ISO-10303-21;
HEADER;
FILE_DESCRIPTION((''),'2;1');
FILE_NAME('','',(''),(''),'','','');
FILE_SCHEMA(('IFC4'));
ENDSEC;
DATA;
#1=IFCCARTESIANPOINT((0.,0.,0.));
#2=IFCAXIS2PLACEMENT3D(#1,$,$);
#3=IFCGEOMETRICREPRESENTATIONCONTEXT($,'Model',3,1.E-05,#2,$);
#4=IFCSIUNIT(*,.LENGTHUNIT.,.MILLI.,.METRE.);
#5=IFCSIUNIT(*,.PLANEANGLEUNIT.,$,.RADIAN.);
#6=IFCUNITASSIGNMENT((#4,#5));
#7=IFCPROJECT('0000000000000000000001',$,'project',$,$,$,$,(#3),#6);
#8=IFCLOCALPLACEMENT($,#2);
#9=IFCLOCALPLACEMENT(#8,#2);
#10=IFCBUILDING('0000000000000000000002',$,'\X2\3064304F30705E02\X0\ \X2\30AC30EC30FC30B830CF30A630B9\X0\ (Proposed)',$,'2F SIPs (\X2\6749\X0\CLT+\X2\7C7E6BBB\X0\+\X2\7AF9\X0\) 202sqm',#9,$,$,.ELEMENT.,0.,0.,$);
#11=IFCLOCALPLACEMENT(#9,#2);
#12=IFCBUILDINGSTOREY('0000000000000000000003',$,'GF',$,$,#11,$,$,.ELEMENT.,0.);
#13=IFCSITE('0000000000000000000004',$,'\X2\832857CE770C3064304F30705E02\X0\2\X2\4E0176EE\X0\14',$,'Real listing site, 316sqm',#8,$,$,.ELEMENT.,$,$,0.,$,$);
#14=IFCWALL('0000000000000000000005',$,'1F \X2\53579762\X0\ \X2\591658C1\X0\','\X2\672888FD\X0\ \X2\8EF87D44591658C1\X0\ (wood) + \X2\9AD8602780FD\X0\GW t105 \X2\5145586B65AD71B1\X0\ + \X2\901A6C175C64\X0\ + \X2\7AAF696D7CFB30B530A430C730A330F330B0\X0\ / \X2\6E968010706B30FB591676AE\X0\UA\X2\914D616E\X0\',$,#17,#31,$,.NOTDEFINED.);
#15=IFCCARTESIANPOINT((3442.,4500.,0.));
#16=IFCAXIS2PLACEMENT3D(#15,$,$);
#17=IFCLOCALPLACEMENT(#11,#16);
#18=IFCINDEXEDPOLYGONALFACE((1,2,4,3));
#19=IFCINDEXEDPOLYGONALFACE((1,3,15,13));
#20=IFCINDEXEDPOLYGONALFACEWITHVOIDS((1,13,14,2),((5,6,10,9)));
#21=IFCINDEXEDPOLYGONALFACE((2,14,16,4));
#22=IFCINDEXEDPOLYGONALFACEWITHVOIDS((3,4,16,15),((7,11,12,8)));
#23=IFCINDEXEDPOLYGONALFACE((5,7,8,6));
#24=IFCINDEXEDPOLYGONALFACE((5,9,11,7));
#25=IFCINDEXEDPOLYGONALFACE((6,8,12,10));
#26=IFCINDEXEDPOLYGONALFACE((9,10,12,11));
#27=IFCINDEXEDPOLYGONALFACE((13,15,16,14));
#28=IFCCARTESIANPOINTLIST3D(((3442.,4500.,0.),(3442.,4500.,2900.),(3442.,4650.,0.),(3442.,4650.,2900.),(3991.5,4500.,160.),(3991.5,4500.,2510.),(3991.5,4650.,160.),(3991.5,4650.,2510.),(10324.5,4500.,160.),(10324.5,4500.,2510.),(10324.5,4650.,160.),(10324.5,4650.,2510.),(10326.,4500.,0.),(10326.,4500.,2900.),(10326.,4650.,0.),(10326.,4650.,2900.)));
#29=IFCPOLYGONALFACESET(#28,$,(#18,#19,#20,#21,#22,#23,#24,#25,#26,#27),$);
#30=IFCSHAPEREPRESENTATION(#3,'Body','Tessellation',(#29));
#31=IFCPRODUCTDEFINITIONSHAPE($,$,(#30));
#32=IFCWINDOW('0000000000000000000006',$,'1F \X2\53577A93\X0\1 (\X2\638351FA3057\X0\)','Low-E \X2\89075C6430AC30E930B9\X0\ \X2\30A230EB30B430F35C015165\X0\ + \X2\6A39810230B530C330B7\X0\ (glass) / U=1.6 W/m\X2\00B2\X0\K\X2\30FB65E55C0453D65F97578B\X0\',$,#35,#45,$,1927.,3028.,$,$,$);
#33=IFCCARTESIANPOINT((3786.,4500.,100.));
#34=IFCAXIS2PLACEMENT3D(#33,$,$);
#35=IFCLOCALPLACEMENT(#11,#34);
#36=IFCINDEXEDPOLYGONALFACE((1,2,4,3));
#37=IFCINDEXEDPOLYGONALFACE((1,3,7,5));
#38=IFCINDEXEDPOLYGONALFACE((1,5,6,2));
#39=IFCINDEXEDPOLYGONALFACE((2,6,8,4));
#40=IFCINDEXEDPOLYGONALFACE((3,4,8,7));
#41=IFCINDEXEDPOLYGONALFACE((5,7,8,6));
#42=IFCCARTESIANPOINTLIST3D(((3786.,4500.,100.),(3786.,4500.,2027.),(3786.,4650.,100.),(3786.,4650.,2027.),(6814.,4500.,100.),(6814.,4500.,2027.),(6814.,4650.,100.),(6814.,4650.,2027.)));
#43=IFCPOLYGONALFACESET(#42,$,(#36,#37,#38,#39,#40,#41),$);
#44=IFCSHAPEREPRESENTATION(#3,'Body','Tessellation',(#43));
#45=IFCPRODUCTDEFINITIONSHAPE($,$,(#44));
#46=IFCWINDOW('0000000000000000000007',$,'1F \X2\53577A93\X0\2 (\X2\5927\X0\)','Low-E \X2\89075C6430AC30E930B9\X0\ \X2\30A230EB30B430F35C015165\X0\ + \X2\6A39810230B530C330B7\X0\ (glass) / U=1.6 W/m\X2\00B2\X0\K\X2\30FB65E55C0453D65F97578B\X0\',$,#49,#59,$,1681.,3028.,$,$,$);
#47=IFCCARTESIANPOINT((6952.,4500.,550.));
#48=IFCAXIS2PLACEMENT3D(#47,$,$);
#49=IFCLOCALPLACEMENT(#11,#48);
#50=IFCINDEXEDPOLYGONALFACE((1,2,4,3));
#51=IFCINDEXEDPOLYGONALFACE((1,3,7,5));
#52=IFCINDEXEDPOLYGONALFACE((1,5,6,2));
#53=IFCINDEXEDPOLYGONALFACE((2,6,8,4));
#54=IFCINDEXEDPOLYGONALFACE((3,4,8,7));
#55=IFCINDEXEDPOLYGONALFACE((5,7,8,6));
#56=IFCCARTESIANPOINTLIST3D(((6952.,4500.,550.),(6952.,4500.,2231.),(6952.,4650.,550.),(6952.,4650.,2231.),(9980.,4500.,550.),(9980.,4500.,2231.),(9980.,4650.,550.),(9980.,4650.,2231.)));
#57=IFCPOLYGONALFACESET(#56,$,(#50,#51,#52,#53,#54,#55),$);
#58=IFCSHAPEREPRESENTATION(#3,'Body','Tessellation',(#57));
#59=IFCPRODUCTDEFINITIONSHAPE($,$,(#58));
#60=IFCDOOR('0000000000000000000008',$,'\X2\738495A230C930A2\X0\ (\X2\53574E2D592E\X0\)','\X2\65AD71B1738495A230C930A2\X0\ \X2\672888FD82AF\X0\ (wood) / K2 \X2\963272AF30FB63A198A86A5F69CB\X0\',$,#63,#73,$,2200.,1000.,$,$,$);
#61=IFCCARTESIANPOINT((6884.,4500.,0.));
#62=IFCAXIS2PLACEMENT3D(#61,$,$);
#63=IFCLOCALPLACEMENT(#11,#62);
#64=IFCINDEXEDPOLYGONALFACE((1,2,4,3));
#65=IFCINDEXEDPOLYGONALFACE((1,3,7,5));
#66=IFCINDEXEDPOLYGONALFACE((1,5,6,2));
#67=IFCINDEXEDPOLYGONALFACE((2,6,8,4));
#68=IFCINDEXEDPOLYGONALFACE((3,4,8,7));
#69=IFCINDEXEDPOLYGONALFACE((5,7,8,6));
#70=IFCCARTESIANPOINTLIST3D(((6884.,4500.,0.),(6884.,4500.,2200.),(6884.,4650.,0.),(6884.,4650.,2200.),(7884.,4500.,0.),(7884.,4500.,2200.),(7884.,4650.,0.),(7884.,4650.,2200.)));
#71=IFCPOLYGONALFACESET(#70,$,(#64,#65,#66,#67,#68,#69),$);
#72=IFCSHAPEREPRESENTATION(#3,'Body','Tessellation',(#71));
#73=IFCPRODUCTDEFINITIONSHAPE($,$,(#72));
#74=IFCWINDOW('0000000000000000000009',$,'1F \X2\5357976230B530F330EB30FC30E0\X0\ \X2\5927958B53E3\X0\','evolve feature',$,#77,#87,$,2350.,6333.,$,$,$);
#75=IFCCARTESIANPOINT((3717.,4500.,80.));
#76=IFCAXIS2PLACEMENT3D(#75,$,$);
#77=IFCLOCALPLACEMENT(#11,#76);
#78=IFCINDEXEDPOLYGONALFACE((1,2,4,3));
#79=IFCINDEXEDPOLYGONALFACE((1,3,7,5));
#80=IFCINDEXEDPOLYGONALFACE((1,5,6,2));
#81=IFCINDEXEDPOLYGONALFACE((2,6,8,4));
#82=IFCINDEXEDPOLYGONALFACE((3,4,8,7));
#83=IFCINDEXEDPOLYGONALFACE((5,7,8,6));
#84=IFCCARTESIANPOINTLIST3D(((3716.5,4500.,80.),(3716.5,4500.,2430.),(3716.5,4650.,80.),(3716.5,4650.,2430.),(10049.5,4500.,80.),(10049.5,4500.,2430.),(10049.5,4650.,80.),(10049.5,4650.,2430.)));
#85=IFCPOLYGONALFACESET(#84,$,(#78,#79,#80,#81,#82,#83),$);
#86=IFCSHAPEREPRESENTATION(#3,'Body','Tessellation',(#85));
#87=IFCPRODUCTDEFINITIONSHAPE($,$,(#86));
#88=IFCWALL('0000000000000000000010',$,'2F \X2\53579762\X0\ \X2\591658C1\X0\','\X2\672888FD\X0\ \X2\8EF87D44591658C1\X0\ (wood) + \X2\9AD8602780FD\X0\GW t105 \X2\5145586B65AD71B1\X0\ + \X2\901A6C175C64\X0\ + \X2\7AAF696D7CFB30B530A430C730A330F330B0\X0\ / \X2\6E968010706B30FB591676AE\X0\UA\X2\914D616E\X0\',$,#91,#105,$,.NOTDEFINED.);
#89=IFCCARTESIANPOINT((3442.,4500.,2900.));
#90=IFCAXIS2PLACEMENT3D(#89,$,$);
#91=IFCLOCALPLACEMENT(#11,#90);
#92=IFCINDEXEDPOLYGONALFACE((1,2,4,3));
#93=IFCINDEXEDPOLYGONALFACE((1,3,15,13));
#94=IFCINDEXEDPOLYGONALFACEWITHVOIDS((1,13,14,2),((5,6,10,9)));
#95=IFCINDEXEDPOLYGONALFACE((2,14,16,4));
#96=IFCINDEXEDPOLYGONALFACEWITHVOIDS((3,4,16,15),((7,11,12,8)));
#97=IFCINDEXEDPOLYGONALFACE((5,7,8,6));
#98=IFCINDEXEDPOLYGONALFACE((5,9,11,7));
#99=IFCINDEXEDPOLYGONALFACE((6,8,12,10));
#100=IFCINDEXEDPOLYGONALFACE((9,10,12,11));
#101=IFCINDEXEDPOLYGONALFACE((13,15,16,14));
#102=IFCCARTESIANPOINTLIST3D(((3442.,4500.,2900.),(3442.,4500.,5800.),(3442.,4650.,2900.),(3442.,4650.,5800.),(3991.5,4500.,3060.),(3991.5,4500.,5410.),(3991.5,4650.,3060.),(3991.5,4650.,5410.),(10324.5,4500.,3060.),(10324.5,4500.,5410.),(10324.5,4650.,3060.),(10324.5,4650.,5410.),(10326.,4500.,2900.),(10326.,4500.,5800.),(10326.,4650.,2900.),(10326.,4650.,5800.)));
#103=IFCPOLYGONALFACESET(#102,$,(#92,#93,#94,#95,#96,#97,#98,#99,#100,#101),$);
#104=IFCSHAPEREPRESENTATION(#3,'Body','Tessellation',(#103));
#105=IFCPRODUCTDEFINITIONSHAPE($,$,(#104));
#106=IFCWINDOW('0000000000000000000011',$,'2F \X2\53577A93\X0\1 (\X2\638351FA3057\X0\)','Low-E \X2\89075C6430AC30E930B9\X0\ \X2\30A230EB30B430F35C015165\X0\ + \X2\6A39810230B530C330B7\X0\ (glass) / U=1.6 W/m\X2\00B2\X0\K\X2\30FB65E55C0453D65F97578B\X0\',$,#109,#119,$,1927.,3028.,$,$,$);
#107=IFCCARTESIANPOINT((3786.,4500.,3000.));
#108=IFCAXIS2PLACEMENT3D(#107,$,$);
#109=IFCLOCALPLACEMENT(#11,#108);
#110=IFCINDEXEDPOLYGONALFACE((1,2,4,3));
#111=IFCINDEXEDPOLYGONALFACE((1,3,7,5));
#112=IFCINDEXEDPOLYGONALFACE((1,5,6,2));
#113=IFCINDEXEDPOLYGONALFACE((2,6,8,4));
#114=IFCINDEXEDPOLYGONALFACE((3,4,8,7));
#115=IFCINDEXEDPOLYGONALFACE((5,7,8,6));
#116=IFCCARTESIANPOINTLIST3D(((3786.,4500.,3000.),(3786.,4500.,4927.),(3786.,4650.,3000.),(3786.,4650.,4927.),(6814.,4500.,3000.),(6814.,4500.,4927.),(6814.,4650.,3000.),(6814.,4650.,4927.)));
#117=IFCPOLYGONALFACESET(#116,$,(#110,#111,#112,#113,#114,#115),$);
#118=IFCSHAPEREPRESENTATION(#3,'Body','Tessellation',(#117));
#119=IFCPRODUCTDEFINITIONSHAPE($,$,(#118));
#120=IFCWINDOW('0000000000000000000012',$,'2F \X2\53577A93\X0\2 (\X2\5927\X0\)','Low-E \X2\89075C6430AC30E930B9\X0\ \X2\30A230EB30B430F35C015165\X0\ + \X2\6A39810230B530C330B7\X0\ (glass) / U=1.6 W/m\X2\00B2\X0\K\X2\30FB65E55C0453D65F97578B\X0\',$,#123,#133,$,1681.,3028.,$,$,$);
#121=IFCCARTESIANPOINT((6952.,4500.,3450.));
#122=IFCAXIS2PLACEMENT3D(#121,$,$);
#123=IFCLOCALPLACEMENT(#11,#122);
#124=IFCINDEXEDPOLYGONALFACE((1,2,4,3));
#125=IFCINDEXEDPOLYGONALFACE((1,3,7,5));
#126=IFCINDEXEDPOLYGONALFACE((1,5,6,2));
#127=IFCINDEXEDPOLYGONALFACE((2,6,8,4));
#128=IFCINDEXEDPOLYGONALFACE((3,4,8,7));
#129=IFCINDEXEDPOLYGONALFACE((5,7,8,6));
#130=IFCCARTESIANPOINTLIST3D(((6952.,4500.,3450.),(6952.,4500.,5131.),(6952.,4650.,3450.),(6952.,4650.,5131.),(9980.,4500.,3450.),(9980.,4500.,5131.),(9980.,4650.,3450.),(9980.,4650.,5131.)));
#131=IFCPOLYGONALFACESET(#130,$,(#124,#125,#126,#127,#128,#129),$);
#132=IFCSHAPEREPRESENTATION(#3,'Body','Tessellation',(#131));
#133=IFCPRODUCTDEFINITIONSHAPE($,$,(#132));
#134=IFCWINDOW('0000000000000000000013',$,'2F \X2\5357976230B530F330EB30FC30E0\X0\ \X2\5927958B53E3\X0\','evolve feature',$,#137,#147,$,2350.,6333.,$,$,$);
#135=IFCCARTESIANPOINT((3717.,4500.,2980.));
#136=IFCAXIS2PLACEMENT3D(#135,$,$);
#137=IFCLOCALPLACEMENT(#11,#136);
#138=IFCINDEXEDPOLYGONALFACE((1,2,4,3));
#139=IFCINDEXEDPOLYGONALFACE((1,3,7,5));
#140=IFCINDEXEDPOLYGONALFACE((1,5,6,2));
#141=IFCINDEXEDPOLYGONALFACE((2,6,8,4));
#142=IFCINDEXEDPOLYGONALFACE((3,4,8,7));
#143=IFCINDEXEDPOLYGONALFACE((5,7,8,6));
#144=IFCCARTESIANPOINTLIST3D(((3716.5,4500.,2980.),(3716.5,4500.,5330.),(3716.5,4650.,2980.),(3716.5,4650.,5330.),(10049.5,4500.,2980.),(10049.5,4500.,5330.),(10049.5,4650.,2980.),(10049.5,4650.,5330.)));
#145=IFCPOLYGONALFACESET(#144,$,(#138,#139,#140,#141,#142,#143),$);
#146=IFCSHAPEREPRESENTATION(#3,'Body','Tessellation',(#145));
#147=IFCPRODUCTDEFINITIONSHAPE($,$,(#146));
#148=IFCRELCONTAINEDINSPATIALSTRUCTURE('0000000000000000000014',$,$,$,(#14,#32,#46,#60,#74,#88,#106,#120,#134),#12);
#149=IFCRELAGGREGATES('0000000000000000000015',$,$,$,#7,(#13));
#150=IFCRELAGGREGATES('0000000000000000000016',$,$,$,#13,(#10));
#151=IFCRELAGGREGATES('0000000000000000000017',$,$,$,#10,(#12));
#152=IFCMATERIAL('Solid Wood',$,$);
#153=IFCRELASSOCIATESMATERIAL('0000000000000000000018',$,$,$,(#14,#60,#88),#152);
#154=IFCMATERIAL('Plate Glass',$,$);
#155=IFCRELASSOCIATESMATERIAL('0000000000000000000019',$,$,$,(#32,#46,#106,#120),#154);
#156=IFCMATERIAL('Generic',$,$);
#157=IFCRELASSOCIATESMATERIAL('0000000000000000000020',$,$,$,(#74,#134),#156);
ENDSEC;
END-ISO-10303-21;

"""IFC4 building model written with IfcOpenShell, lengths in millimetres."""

from ifc_helpers import new_model, si_unit, frame, frame_2d, origin, place, context, project, spatial, rectangle, extrude, material, element, fill, save


model = new_model("IFC4")

# Units and contexts
model_context = context("Model", 3, precision=1e-05, world=origin())
ifc_project = project(units=[si_unit("LENGTHUNIT", "METRE", prefix="MILLI"), si_unit("PLANEANGLEUNIT", "RADIAN")], contexts=[model_context])

# Site, building, storey
site_placement = place(None, origin())
site = spatial("IfcSite", under=ifc_project, at=site_placement, Name="茨城県つくば市2丁目14", ObjectType="Real listing site, 316sqm", CompositionType="ELEMENT", RefElevation=0.0)
building_placement = place(site_placement, origin())
building = spatial("IfcBuilding", under=site, at=building_placement, Name="つくば市 ガレージハウス (Proposed)", ObjectType="2F SIPs (杉CLT+籾殻+竹) 202sqm", CompositionType="ELEMENT", ElevationOfRefHeight=0.0, ElevationOfTerrain=0.0)
storey_placement = place(building_placement, origin())
storey = spatial("IfcBuildingStorey", under=building, at=storey_placement, Name="GF", CompositionType="ELEMENT", Elevation=0.0)

# Shared definitions
ifc_material_1 = material(Name="Solid Wood")

# Wall, openings, windows, door
wall_1_placement = place(storey_placement, frame((3442.0, 4500.0, 0.0)))
wall_1 = element("IfcWall", 1, at=wall_1_placement, inside=storey, material=ifc_material_1, Name="1F 南面 外壁", Description="木製 軸組外壁 (wood) + 高性能GW t105 充填断熱 + 通気層 + 窯業系サイディング / 準耐火・外皮UA配慮", PredefinedType="NOTDEFINED", context=model_context, shape_type="SweptSolid", body=[
    extrude(rectangle(XDim=6884.0, YDim=150.0, at=frame_2d((3442.0, 75.0))), frame((3442.0, 4500.0, 0.0)), (0.0, 0.0, 1.0), 2900.0),
])
opening_1_placement = place(storey_placement, frame((3786.0, 4500.0, 100.0)))
opening_1 = element("IfcOpeningElement", 2, at=opening_1_placement, cuts=wall_1, PredefinedType="NOTDEFINED", context=model_context, shape_type="SweptSolid", body=[
    extrude(rectangle(XDim=3028.0, YDim=150.0, at=frame_2d((1514.0, 75.0))), frame((3786.0, 4500.0, 100.0)), (0.0, 0.0, 1.0), 1927.0),
])
opening_2_placement = place(storey_placement, frame((6952.0, 4500.0, 550.0)))
opening_2 = element("IfcOpeningElement", 3, at=opening_2_placement, cuts=wall_1, PredefinedType="NOTDEFINED", context=model_context, shape_type="SweptSolid", body=[
    extrude(rectangle(XDim=3028.0, YDim=150.0, at=frame_2d((1514.0, 75.0))), frame((6952.0, 4500.0, 550.0)), (0.0, 0.0, 1.0), 1681.0),
])
opening_3_placement = place(storey_placement, frame((6884.0, 4500.0, 0.0)))
opening_3 = element("IfcOpeningElement", 4, at=opening_3_placement, cuts=wall_1, PredefinedType="NOTDEFINED", context=model_context, shape_type="SweptSolid", body=[
    extrude(rectangle(XDim=1000.0, YDim=150.0, at=frame_2d((500.0, 75.0))), frame((6884.0, 4500.0, 0.0)), (0.0, 0.0, 1.0), 2200.0),
])
opening_4_placement = place(storey_placement, frame((3717.0, 4500.0, 80.0)))
opening_4 = element("IfcOpeningElement", 5, at=opening_4_placement, cuts=wall_1, PredefinedType="NOTDEFINED", context=model_context, shape_type="SweptSolid", body=[
    extrude(rectangle(XDim=6333.0, YDim=150.0, at=frame_2d((3166.0, 75.0))), frame((3717.0, 4500.0, 80.0)), (0.0, 0.0, 1.0), 2350.0),
])
ifc_material_2 = material(Name="Plate Glass")
window_1_placement = place(storey_placement, frame((3786.0, 4500.0, 100.0)))
window_1 = element("IfcWindow", 6, at=window_1_placement, inside=storey, material=ifc_material_2, Name="1F 南窓1 (掃出し)", Description="Low-E 複層ガラス アルゴン封入 + 樹脂サッシ (glass) / U=1.6 W/m²K・日射取得型", OverallHeight=1927.0, OverallWidth=3028.0, context=model_context, shape_type="SweptSolid", body=[
    extrude(rectangle(XDim=3028.0, YDim=150.0, at=frame_2d((1514.0, 75.0))), frame((3786.0, 4500.0, 100.0)), (0.0, 0.0, 1.0), 1927.0),
])
fill(opening_1, window_1)
window_2_placement = place(storey_placement, frame((6952.0, 4500.0, 550.0)))
window_2 = element("IfcWindow", 7, at=window_2_placement, inside=storey, material=ifc_material_2, Name="1F 南窓2 (大)", Description="Low-E 複層ガラス アルゴン封入 + 樹脂サッシ (glass) / U=1.6 W/m²K・日射取得型", OverallHeight=1681.0, OverallWidth=3028.0, context=model_context, shape_type="SweptSolid", body=[
    extrude(rectangle(XDim=3028.0, YDim=150.0, at=frame_2d((1514.0, 75.0))), frame((6952.0, 4500.0, 550.0)), (0.0, 0.0, 1.0), 1681.0),
])
fill(opening_2, window_2)
door_placement = place(storey_placement, frame((6884.0, 4500.0, 0.0)))
door = element("IfcDoor", 8, at=door_placement, inside=storey, material=ifc_material_1, Name="玄関ドア (南中央)", Description="断熱玄関ドア 木製芯 (wood) / K2 防犯・採風機構", OverallHeight=2200.0, OverallWidth=1000.0, context=model_context, shape_type="SweptSolid", body=[
    extrude(rectangle(XDim=1000.0, YDim=150.0, at=frame_2d((500.0, 75.0))), frame((6884.0, 4500.0, 0.0)), (0.0, 0.0, 1.0), 2200.0),
])
fill(opening_3, door)
ifc_material_3 = material(Name="Generic")
window_3_placement = place(storey_placement, frame((3717.0, 4500.0, 80.0)))
window_3 = element("IfcWindow", 9, at=window_3_placement, inside=storey, material=ifc_material_3, Name="1F 南面サンルーム 大開口", Description="evolve feature", OverallHeight=2350.0, OverallWidth=6333.0, context=model_context, shape_type="SweptSolid", body=[
    extrude(rectangle(XDim=6333.0, YDim=150.0, at=frame_2d((3166.0, 75.0))), frame((3717.0, 4500.0, 80.0)), (0.0, 0.0, 1.0), 2350.0),
])
fill(opening_4, window_3)

# Wall, openings, windows
wall_2_placement = place(storey_placement, frame((3442.0, 4500.0, 2900.0)))
wall_2 = element("IfcWall", 10, at=wall_2_placement, inside=storey, material=ifc_material_1, Name="2F 南面 外壁", Description="木製 軸組外壁 (wood) + 高性能GW t105 充填断熱 + 通気層 + 窯業系サイディング / 準耐火・外皮UA配慮", PredefinedType="NOTDEFINED", context=model_context, shape_type="SweptSolid", body=[
    extrude(rectangle(XDim=6884.0, YDim=150.0, at=frame_2d((3442.0, 75.0))), frame((3442.0, 4500.0, 2900.0)), (0.0, 0.0, 1.0), 2900.0),
])
opening_5_placement = place(storey_placement, frame((3786.0, 4500.0, 3000.0)))
opening_5 = element("IfcOpeningElement", 11, at=opening_5_placement, cuts=wall_2, PredefinedType="NOTDEFINED", context=model_context, shape_type="SweptSolid", body=[
    extrude(rectangle(XDim=3028.0, YDim=150.0, at=frame_2d((1514.0, 75.0))), frame((3786.0, 4500.0, 3000.0)), (0.0, 0.0, 1.0), 1927.0),
])
opening_6_placement = place(storey_placement, frame((6952.0, 4500.0, 3450.0)))
opening_6 = element("IfcOpeningElement", 12, at=opening_6_placement, cuts=wall_2, PredefinedType="NOTDEFINED", context=model_context, shape_type="SweptSolid", body=[
    extrude(rectangle(XDim=3028.0, YDim=150.0, at=frame_2d((1514.0, 75.0))), frame((6952.0, 4500.0, 3450.0)), (0.0, 0.0, 1.0), 1681.0),
])
opening_7_placement = place(storey_placement, frame((3717.0, 4500.0, 2980.0)))
opening_7 = element("IfcOpeningElement", 13, at=opening_7_placement, cuts=wall_2, PredefinedType="NOTDEFINED", context=model_context, shape_type="SweptSolid", body=[
    extrude(rectangle(XDim=6333.0, YDim=150.0, at=frame_2d((3166.0, 75.0))), frame((3717.0, 4500.0, 2980.0)), (0.0, 0.0, 1.0), 2350.0),
])
window_4_placement = place(storey_placement, frame((3786.0, 4500.0, 3000.0)))
window_4 = element("IfcWindow", 14, at=window_4_placement, inside=storey, material=ifc_material_2, Name="2F 南窓1 (掃出し)", Description="Low-E 複層ガラス アルゴン封入 + 樹脂サッシ (glass) / U=1.6 W/m²K・日射取得型", OverallHeight=1927.0, OverallWidth=3028.0, context=model_context, shape_type="SweptSolid", body=[
    extrude(rectangle(XDim=3028.0, YDim=150.0, at=frame_2d((1514.0, 75.0))), frame((3786.0, 4500.0, 3000.0)), (0.0, 0.0, 1.0), 1927.0),
])
fill(opening_5, window_4)
window_5_placement = place(storey_placement, frame((6952.0, 4500.0, 3450.0)))
window_5 = element("IfcWindow", 15, at=window_5_placement, inside=storey, material=ifc_material_2, Name="2F 南窓2 (大)", Description="Low-E 複層ガラス アルゴン封入 + 樹脂サッシ (glass) / U=1.6 W/m²K・日射取得型", OverallHeight=1681.0, OverallWidth=3028.0, context=model_context, shape_type="SweptSolid", body=[
    extrude(rectangle(XDim=3028.0, YDim=150.0, at=frame_2d((1514.0, 75.0))), frame((6952.0, 4500.0, 3450.0)), (0.0, 0.0, 1.0), 1681.0),
])
fill(opening_6, window_5)
window_6_placement = place(storey_placement, frame((3717.0, 4500.0, 2980.0)))
window_6 = element("IfcWindow", 16, at=window_6_placement, inside=storey, material=ifc_material_3, Name="2F 南面サンルーム 大開口", Description="evolve feature", OverallHeight=2350.0, OverallWidth=6333.0, context=model_context, shape_type="SweptSolid", body=[
    extrude(rectangle(XDim=6333.0, YDim=150.0, at=frame_2d((3166.0, 75.0))), frame((3717.0, 4500.0, 2980.0)), (0.0, 0.0, 1.0), 2350.0),
])
fill(opening_7, window_6)

save(model, "model.ifc")
